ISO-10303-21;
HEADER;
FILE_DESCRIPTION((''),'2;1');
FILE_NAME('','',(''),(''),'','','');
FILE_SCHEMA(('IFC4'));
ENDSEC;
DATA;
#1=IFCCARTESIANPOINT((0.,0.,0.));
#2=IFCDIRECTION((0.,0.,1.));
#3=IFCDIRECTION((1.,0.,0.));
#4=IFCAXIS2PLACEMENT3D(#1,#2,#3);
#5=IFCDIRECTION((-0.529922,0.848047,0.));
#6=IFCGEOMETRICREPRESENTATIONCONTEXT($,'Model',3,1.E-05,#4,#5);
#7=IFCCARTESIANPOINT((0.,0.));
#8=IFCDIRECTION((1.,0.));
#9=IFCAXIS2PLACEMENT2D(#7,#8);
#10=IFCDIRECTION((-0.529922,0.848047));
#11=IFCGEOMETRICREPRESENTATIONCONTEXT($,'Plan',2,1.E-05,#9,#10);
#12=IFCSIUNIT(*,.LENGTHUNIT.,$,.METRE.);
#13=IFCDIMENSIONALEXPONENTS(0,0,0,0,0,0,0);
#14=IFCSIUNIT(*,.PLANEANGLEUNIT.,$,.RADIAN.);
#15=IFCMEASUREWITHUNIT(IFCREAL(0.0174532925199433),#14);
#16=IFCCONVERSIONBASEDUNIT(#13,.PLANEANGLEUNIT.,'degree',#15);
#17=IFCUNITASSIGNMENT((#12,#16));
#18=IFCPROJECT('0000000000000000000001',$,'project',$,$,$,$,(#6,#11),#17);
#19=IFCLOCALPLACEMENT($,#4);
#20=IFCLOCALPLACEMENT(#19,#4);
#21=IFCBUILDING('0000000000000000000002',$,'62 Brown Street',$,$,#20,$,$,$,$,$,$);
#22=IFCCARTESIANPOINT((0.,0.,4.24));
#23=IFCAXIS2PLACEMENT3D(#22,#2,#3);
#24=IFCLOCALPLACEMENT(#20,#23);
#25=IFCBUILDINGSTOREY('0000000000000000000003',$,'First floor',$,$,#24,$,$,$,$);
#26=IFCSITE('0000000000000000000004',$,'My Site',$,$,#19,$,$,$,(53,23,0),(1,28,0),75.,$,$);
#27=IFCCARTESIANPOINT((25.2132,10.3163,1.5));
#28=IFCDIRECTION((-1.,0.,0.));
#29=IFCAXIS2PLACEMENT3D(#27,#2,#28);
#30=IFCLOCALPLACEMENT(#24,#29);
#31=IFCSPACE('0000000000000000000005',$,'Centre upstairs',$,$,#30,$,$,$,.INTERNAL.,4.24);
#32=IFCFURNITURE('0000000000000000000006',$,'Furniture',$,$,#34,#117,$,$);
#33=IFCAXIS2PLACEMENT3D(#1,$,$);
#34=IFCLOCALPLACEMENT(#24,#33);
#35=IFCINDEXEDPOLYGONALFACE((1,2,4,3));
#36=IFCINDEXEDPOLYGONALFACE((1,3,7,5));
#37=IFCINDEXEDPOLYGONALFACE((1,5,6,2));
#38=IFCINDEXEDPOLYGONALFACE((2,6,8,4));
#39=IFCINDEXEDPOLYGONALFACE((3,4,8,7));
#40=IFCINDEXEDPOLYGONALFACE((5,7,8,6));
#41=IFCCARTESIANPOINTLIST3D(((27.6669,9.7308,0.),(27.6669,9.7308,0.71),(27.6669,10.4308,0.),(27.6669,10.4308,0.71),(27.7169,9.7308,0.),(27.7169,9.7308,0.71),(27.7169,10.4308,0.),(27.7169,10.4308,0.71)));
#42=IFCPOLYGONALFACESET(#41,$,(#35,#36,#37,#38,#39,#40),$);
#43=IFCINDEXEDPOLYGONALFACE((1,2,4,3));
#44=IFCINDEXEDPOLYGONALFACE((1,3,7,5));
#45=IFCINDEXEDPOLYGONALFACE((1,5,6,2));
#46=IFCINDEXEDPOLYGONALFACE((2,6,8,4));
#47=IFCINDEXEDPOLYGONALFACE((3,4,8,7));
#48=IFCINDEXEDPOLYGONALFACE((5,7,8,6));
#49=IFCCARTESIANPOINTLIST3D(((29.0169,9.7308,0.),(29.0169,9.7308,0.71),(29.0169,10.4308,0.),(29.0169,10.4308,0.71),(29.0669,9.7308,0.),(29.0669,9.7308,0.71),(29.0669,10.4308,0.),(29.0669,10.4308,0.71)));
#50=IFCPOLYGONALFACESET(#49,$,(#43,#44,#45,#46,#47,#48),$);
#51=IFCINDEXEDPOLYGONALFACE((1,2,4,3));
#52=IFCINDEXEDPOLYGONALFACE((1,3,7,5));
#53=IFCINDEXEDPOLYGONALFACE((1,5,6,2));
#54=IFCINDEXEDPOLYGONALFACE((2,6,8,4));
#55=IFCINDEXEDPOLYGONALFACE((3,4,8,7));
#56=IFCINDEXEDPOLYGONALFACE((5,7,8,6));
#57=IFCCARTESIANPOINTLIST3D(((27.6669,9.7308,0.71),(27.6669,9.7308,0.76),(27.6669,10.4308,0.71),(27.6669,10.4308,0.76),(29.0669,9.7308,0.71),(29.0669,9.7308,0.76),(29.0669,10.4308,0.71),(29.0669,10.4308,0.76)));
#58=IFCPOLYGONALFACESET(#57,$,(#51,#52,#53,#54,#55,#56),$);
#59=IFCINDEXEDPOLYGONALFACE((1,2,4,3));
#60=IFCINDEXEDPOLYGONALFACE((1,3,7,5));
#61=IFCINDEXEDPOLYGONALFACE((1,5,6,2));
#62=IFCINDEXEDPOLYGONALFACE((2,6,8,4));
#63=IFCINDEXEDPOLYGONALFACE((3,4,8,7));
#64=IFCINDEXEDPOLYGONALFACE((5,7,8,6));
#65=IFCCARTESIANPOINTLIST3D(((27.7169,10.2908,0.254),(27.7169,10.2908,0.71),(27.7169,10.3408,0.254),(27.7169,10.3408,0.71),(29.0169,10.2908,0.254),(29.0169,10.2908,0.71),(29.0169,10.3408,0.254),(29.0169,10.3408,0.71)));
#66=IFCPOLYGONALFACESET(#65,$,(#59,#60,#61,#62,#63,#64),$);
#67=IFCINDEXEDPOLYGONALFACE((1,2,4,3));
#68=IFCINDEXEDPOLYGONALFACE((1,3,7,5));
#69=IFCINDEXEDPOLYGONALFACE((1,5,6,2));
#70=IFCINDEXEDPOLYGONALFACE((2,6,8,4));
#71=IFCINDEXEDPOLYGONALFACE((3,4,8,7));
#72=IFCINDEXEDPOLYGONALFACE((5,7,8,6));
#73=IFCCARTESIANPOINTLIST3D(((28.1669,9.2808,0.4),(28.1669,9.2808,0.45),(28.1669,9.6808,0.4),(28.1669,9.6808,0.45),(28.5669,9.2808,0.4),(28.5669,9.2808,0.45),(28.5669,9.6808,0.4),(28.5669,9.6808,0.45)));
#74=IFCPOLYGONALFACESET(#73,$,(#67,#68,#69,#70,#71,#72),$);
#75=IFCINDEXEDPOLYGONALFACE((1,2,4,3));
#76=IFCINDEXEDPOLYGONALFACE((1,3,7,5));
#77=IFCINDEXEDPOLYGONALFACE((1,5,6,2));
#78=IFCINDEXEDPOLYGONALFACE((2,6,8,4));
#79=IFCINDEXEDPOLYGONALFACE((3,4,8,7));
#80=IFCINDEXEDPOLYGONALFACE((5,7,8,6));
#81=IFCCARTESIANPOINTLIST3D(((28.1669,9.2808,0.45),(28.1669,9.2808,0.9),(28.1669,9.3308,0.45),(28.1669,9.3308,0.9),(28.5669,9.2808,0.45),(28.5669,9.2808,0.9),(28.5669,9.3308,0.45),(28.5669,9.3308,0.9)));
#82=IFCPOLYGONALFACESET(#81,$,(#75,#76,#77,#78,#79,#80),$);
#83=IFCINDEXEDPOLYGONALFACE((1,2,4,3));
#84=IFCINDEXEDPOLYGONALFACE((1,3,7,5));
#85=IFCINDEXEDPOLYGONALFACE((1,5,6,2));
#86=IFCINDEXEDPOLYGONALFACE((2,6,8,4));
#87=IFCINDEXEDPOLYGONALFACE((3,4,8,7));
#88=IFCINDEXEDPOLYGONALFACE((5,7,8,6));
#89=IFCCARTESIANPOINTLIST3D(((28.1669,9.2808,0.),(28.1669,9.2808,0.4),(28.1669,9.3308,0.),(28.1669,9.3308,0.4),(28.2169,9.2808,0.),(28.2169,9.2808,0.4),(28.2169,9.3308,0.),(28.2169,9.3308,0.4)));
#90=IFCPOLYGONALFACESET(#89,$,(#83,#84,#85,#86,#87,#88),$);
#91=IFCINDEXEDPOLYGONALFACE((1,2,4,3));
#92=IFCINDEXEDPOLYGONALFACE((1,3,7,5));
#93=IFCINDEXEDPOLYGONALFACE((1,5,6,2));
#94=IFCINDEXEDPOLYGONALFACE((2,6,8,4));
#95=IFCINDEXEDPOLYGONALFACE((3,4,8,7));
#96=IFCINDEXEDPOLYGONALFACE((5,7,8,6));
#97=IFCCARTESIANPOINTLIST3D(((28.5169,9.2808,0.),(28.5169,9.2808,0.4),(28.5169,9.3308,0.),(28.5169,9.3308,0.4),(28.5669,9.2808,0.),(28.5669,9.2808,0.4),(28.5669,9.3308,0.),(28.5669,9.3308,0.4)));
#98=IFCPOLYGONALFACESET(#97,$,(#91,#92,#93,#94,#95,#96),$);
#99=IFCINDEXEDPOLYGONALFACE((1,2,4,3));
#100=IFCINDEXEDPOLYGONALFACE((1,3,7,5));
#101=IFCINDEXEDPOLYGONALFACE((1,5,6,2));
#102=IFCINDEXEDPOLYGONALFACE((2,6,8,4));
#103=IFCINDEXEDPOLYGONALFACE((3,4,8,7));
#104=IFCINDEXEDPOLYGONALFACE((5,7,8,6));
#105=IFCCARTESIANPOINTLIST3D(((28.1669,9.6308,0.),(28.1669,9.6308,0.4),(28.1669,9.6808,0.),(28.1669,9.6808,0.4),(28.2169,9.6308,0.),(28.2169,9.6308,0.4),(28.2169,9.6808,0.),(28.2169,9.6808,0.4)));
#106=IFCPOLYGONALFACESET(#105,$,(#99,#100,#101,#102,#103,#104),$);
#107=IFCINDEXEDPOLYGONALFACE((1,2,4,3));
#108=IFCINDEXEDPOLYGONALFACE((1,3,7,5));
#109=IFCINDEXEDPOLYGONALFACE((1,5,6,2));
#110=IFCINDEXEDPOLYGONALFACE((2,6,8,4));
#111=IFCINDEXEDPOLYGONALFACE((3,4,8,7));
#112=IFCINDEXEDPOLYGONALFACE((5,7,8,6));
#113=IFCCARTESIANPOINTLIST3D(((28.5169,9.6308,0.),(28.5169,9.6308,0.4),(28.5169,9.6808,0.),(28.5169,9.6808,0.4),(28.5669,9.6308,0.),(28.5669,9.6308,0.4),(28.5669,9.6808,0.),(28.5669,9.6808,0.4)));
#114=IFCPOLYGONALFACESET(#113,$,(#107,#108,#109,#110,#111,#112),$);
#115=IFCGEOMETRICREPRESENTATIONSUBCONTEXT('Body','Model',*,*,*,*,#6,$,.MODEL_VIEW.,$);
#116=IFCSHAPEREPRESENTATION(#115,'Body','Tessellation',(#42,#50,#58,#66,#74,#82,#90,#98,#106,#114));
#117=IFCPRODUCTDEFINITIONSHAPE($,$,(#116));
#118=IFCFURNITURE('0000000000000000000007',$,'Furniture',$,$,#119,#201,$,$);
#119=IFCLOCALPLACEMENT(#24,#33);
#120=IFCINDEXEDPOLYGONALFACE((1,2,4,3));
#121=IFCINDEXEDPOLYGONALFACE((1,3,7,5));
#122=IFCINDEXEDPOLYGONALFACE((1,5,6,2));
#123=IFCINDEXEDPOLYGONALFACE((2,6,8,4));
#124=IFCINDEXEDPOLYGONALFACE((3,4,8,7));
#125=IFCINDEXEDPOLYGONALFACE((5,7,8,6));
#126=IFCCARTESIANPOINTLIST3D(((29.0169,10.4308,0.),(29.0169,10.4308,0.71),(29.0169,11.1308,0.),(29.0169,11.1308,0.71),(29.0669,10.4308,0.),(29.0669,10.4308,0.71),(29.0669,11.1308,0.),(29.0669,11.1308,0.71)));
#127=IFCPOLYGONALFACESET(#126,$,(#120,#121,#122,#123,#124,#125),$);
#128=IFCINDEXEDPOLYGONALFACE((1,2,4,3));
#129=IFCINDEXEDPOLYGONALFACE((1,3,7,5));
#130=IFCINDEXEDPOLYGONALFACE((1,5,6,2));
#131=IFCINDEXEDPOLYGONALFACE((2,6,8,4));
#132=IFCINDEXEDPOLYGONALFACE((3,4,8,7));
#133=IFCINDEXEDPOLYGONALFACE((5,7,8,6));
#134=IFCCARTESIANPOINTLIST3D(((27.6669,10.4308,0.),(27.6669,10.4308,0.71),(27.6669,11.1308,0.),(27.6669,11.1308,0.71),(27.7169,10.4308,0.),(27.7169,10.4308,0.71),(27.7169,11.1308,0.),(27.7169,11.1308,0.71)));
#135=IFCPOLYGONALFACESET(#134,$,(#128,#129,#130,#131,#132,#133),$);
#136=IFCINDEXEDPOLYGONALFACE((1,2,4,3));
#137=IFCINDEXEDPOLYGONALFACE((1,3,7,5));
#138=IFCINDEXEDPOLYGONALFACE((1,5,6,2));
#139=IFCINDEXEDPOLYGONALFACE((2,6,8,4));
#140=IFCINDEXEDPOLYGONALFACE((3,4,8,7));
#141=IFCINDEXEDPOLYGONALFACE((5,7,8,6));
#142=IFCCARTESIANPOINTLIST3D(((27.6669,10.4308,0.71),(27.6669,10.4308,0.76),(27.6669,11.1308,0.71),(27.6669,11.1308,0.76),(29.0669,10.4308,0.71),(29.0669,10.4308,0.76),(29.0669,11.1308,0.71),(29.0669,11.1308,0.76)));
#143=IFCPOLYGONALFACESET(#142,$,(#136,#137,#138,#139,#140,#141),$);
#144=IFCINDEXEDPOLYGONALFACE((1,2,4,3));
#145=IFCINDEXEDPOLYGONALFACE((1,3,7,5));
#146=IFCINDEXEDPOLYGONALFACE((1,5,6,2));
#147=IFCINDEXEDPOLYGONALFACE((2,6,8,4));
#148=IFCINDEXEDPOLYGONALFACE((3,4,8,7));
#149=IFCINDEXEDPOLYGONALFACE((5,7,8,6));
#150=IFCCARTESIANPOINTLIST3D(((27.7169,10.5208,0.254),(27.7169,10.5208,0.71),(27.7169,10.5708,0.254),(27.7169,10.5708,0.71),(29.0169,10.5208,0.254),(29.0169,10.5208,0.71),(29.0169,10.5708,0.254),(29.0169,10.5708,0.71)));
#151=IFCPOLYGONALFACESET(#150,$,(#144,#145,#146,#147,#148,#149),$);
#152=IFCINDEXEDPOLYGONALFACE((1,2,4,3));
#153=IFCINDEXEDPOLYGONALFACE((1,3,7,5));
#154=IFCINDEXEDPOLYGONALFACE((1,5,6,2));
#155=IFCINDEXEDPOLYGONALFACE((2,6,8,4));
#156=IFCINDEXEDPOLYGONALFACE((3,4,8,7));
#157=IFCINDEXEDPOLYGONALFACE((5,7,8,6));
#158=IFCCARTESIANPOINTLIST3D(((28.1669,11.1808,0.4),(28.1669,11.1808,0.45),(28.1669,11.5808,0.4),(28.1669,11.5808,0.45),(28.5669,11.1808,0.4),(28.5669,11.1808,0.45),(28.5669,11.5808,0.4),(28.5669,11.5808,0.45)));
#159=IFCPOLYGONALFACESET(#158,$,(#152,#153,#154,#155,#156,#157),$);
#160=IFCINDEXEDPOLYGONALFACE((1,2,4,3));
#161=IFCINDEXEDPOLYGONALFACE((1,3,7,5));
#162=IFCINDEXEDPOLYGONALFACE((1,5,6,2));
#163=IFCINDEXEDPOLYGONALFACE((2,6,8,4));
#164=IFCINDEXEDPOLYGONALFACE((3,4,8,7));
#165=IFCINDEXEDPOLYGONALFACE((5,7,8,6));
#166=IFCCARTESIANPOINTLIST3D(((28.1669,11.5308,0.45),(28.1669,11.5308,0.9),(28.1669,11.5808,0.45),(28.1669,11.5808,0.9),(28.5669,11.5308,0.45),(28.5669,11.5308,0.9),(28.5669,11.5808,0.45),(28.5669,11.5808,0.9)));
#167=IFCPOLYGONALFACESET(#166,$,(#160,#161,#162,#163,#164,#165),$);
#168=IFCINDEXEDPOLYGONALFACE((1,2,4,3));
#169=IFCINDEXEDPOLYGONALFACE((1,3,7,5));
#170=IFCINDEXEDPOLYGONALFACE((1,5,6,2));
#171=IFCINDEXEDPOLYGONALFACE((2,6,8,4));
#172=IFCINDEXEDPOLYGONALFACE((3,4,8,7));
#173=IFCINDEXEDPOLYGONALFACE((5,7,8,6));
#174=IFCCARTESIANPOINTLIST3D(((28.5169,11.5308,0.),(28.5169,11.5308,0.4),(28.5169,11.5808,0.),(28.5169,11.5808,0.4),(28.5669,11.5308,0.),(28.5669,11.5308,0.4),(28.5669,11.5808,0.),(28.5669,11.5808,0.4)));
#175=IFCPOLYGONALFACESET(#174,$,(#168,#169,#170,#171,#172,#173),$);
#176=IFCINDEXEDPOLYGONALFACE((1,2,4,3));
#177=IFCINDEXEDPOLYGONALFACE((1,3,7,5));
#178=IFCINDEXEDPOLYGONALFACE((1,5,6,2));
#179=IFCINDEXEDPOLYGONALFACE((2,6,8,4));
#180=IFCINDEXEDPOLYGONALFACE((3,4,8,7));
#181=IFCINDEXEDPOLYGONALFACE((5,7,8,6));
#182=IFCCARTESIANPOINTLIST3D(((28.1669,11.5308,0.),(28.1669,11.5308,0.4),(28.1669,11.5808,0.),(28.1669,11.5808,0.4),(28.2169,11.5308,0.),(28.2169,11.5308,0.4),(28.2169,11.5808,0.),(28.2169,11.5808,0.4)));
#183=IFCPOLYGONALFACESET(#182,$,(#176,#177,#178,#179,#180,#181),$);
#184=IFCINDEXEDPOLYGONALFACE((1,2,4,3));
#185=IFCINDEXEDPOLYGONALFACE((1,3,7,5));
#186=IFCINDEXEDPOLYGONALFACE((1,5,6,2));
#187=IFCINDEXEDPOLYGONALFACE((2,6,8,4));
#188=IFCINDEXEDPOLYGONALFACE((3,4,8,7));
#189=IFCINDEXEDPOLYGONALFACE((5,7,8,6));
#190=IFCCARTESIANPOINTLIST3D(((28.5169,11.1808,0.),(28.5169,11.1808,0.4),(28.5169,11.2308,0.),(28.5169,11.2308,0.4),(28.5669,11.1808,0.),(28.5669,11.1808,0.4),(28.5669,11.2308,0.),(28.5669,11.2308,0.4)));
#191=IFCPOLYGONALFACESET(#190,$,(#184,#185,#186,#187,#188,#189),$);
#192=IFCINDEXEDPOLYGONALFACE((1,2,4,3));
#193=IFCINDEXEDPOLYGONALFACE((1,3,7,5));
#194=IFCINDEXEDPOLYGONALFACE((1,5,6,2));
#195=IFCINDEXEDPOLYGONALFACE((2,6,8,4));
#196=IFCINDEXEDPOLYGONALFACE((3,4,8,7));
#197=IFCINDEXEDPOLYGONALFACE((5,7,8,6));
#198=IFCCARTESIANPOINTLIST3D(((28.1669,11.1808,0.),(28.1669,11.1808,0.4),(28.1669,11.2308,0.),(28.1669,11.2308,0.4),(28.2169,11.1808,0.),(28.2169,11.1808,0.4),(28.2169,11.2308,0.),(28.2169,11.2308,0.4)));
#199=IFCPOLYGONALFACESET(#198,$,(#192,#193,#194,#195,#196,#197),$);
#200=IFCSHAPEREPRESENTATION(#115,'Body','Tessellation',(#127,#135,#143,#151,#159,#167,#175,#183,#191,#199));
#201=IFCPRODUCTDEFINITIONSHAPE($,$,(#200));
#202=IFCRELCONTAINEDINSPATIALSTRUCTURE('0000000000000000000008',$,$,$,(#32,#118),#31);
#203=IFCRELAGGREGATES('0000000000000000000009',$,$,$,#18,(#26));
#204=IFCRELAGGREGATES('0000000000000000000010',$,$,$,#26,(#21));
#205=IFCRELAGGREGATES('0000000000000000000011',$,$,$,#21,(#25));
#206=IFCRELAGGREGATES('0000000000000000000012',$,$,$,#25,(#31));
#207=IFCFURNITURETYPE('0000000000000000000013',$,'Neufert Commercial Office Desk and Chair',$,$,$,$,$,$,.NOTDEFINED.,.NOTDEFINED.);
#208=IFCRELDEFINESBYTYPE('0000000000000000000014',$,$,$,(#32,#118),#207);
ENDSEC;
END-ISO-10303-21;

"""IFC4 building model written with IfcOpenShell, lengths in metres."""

from ifc_helpers import new_model, entity, si_unit, converted_unit, direction, frame, origin_with_axes, origin_2d_with_axis, place, context, subcontext, project, spatial, line, indexed_curve, outline, extrude, shape, source, transform, mapped, type_object, type_shapes, element, save


model = new_model("IFC4")

# Units and contexts
model_context = context("Model", 3, precision=1e-05, world=origin_with_axes(), true_north=direction((-0.529922, 0.848047, 0.0)))
plan_context = context("Plan", 2, precision=1e-05, world=origin_2d_with_axis(), true_north=direction((-0.529922, 0.848047)))
body_context_1 = subcontext(model_context, "Body", "Model", "MODEL_VIEW")
body_context_2 = subcontext(plan_context, "Body", "Plan", "PLAN_VIEW")
ifc_project = project(units=[si_unit("LENGTHUNIT", "METRE"), converted_unit("PLANEANGLEUNIT", "degree", entity("IfcReal", 0.0174532925199433), si_unit("PLANEANGLEUNIT", "RADIAN"), dimensions=[0, 0, 0, 0, 0, 0, 0])], contexts=[model_context, plan_context])

# Site, building, storey, space
site_placement = place(None, origin_with_axes())
site = spatial("IfcSite", under=ifc_project, at=site_placement, Name="My Site", RefLatitude=(53, 23, 0), RefLongitude=(1, 28, 0), RefElevation=75.0)
building_placement = place(site_placement, origin_with_axes())
building = spatial("IfcBuilding", under=site, at=building_placement, Name="62 Brown Street")
storey_placement = place(building_placement, frame((0.0, 0.0, 4.24), z_axis=(0.0, 0.0, 1.0), x_axis=(1.0, 0.0, 0.0)))
storey = spatial("IfcBuildingStorey", under=building, at=storey_placement, Name="First floor")
space_placement = place(storey_placement, frame((25.2132, 10.3163, 1.5), z_axis=(0.0, 0.0, 1.0), x_axis=(-1.0, 0.0, 0.0)))
space = spatial("IfcSpace", under=storey, at=space_placement, Name="Centre upstairs", PredefinedType="INTERNAL", ElevationWithFlooring=4.24)

# Furniture
furniture_type = type_object("IfcFurnitureType", Name="Neufert Commercial Office Desk and Chair", AssemblyPlace="NOTDEFINED", PredefinedType="NOTDEFINED")
shared_shape_1 = source(origin_with_axes(), body_context_1, "Body", "SweptSolid", [
    extrude(outline(indexed_curve([(0.0, 0.0), (0.05, 0.0), (0.05, 0.7), (0.0, 0.7)], segments=[line(1, 2, 3, 4, 1)])), frame((0.0, 0.45, 0.0), z_axis=(0.0, 0.0, 1.0), x_axis=(1.0, 0.0, 0.0)), (0.0, 0.0, 1.0), 0.71),
    extrude(outline(indexed_curve([(0.0, 0.0), (0.05, 0.0), (0.05, 0.7), (0.0, 0.7)], segments=[line(1, 2, 3, 4, 1)])), frame((1.35, 0.45, 0.0), z_axis=(0.0, 0.0, 1.0), x_axis=(1.0, 0.0, 0.0)), (0.0, 0.0, 1.0), 0.71),
    extrude(outline(indexed_curve([(0.0, 0.0), (1.4, 0.0), (1.4, 0.7), (0.0, 0.7)], segments=[line(1, 2, 3, 4, 1)])), frame((0.0, 0.45, 0.71), z_axis=(0.0, 0.0, 1.0), x_axis=(1.0, 0.0, 0.0)), (0.0, 0.0, 1.0), 0.05),
    extrude(outline(indexed_curve([(0.05, 0.56), (1.35, 0.56), (1.35, 0.61), (0.05, 0.61)], segments=[line(1, 2, 3, 4, 1)])), frame((0.0, 0.45, 0.254), z_axis=(0.0, 0.0, 1.0), x_axis=(1.0, 0.0, 0.0)), (0.0, 0.0, 1.0), 0.456),
    extrude(outline(indexed_curve([(-0.2, 0.0), (0.2, 0.0), (0.2, 0.4), (-0.2, 0.4)], segments=[line(1, 2, 3, 4, 1)])), frame((0.7, 0.0, 0.45), z_axis=(0.0, 0.0, 1.0), x_axis=(1.0, 0.0, 0.0)), (0.0, 0.0, -1.0), 0.05),
    extrude(outline(indexed_curve([(-0.2, 0.0), (0.2, 0.0), (0.2, 0.05), (-0.2, 0.05)], segments=[line(1, 2, 3, 4, 1)])), frame((0.7, 0.0, 0.9), z_axis=(0.0, 0.0, 1.0), x_axis=(1.0, 0.0, 0.0)), (0.0, 0.0, -1.0), 0.45),
    extrude(outline(indexed_curve([(-0.2, 0.0), (-0.15, 0.0), (-0.15, 0.05), (-0.2, 0.05)], segments=[line(1, 2, 3, 4, 1)])), frame((0.7, 0.0, 0.0), z_axis=(0.0, 0.0, 1.0), x_axis=(1.0, 0.0, 0.0)), (0.0, 0.0, 1.0), 0.4),
    extrude(outline(indexed_curve([(0.2, 0.0), (0.15, 0.0), (0.15, 0.05), (0.2, 0.05)], segments=[line(1, 2, 3, 4, 1)])), frame((0.7, 0.0, 0.0), z_axis=(0.0, 0.0, 1.0), x_axis=(1.0, 0.0, 0.0)), (0.0, 0.0, 1.0), 0.4),
    extrude(outline(indexed_curve([(-0.2, 0.4), (-0.15, 0.4), (-0.15, 0.35), (-0.2, 0.35)], segments=[line(1, 2, 3, 4, 1)])), frame((0.7, 0.0, 0.0), z_axis=(0.0, 0.0, 1.0), x_axis=(1.0, 0.0, 0.0)), (0.0, 0.0, 1.0), 0.4),
    extrude(outline(indexed_curve([(0.2, 0.4), (0.15, 0.4), (0.15, 0.35), (0.2, 0.35)], segments=[line(1, 2, 3, 4, 1)])), frame((0.7, 0.0, 0.0), z_axis=(0.0, 0.0, 1.0), x_axis=(1.0, 0.0, 0.0)), (0.0, 0.0, 1.0), 0.4),
])
shared_shape_2 = source(origin_with_axes(), body_context_2, "Body", "Curve2D", [
    entity("IfcIndexedPolyCurve", entity("IfcCartesianPointList2D", [[0.0, 0.45], [1.4, 0.45], [1.4, 1.15], [0.0, 1.15]]), [entity("IfcLineIndex", [1, 2, 3, 4, 1])]),
    entity("IfcIndexedPolyCurve", entity("IfcCartesianPointList2D", [[0.5, 0.4], [0.9, 0.4]])),
    entity("IfcIndexedPolyCurve", entity("IfcCartesianPointList2D", [[0.5, 0.4], [0.5, 0.2], [0.5586, 0.0586], [0.7, 0.0], [0.8414, 0.0586], [0.9, 0.2], [0.9, 0.4]]), [entity("IfcLineIndex", [1, 2]), entity("IfcArcIndex", [2, 3, 4]), entity("IfcArcIndex", [4, 5, 6]), entity("IfcLineIndex", [6, 7])]),
    entity("IfcIndexedPolyCurve", entity("IfcCartesianPointList2D", [[0.54, 0.4], [0.54, 0.2], [0.5869, 0.0869], [0.7, 0.04], [0.8131, 0.0869], [0.86, 0.2], [0.86, 0.4]]), [entity("IfcLineIndex", [1, 2]), entity("IfcArcIndex", [2, 3, 4]), entity("IfcArcIndex", [4, 5, 6]), entity("IfcLineIndex", [6, 7])]),
])
type_shapes(furniture_type, [shared_shape_1, shared_shape_2])
for number, where, z_axis, x_axis, name in (
    (1, (-2.4537, 1.0355, -1.5), (0.0, 0.0, 1.0), (-1.0, 0.0, 0.0), "Furniture"),
    (2, (-3.8537, -1.2645, -1.5), (0.0, 0.0, 1.0), (1.0, 0.0, 0.0), "Furniture"),
):
    element("IfcFurniture", number, at=place(space_placement, frame(where, z_axis=z_axis, x_axis=x_axis)), inside=space, type_object=furniture_type, Name=name, shapes=[
        shape(body_context_1, "Body", "MappedRepresentation", [mapped(shared_shape_1, transform((0.0, 0.0, 0.0), x_axis=(1.0, 0.0, 0.0), y_axis=(0.0, 1.0, 0.0), z_axis=(0.0, 0.0, 1.0), scale=1.0))]),
        shape(body_context_2, "Body", "MappedRepresentation", [mapped(shared_shape_2, transform((0.0, 0.0, 0.0), x_axis=(1.0, 0.0, 0.0), y_axis=(0.0, 1.0, 0.0), z_axis=(0.0, 0.0, 1.0), scale=1.0))]),
    ])

save(model, "model.ifc")
